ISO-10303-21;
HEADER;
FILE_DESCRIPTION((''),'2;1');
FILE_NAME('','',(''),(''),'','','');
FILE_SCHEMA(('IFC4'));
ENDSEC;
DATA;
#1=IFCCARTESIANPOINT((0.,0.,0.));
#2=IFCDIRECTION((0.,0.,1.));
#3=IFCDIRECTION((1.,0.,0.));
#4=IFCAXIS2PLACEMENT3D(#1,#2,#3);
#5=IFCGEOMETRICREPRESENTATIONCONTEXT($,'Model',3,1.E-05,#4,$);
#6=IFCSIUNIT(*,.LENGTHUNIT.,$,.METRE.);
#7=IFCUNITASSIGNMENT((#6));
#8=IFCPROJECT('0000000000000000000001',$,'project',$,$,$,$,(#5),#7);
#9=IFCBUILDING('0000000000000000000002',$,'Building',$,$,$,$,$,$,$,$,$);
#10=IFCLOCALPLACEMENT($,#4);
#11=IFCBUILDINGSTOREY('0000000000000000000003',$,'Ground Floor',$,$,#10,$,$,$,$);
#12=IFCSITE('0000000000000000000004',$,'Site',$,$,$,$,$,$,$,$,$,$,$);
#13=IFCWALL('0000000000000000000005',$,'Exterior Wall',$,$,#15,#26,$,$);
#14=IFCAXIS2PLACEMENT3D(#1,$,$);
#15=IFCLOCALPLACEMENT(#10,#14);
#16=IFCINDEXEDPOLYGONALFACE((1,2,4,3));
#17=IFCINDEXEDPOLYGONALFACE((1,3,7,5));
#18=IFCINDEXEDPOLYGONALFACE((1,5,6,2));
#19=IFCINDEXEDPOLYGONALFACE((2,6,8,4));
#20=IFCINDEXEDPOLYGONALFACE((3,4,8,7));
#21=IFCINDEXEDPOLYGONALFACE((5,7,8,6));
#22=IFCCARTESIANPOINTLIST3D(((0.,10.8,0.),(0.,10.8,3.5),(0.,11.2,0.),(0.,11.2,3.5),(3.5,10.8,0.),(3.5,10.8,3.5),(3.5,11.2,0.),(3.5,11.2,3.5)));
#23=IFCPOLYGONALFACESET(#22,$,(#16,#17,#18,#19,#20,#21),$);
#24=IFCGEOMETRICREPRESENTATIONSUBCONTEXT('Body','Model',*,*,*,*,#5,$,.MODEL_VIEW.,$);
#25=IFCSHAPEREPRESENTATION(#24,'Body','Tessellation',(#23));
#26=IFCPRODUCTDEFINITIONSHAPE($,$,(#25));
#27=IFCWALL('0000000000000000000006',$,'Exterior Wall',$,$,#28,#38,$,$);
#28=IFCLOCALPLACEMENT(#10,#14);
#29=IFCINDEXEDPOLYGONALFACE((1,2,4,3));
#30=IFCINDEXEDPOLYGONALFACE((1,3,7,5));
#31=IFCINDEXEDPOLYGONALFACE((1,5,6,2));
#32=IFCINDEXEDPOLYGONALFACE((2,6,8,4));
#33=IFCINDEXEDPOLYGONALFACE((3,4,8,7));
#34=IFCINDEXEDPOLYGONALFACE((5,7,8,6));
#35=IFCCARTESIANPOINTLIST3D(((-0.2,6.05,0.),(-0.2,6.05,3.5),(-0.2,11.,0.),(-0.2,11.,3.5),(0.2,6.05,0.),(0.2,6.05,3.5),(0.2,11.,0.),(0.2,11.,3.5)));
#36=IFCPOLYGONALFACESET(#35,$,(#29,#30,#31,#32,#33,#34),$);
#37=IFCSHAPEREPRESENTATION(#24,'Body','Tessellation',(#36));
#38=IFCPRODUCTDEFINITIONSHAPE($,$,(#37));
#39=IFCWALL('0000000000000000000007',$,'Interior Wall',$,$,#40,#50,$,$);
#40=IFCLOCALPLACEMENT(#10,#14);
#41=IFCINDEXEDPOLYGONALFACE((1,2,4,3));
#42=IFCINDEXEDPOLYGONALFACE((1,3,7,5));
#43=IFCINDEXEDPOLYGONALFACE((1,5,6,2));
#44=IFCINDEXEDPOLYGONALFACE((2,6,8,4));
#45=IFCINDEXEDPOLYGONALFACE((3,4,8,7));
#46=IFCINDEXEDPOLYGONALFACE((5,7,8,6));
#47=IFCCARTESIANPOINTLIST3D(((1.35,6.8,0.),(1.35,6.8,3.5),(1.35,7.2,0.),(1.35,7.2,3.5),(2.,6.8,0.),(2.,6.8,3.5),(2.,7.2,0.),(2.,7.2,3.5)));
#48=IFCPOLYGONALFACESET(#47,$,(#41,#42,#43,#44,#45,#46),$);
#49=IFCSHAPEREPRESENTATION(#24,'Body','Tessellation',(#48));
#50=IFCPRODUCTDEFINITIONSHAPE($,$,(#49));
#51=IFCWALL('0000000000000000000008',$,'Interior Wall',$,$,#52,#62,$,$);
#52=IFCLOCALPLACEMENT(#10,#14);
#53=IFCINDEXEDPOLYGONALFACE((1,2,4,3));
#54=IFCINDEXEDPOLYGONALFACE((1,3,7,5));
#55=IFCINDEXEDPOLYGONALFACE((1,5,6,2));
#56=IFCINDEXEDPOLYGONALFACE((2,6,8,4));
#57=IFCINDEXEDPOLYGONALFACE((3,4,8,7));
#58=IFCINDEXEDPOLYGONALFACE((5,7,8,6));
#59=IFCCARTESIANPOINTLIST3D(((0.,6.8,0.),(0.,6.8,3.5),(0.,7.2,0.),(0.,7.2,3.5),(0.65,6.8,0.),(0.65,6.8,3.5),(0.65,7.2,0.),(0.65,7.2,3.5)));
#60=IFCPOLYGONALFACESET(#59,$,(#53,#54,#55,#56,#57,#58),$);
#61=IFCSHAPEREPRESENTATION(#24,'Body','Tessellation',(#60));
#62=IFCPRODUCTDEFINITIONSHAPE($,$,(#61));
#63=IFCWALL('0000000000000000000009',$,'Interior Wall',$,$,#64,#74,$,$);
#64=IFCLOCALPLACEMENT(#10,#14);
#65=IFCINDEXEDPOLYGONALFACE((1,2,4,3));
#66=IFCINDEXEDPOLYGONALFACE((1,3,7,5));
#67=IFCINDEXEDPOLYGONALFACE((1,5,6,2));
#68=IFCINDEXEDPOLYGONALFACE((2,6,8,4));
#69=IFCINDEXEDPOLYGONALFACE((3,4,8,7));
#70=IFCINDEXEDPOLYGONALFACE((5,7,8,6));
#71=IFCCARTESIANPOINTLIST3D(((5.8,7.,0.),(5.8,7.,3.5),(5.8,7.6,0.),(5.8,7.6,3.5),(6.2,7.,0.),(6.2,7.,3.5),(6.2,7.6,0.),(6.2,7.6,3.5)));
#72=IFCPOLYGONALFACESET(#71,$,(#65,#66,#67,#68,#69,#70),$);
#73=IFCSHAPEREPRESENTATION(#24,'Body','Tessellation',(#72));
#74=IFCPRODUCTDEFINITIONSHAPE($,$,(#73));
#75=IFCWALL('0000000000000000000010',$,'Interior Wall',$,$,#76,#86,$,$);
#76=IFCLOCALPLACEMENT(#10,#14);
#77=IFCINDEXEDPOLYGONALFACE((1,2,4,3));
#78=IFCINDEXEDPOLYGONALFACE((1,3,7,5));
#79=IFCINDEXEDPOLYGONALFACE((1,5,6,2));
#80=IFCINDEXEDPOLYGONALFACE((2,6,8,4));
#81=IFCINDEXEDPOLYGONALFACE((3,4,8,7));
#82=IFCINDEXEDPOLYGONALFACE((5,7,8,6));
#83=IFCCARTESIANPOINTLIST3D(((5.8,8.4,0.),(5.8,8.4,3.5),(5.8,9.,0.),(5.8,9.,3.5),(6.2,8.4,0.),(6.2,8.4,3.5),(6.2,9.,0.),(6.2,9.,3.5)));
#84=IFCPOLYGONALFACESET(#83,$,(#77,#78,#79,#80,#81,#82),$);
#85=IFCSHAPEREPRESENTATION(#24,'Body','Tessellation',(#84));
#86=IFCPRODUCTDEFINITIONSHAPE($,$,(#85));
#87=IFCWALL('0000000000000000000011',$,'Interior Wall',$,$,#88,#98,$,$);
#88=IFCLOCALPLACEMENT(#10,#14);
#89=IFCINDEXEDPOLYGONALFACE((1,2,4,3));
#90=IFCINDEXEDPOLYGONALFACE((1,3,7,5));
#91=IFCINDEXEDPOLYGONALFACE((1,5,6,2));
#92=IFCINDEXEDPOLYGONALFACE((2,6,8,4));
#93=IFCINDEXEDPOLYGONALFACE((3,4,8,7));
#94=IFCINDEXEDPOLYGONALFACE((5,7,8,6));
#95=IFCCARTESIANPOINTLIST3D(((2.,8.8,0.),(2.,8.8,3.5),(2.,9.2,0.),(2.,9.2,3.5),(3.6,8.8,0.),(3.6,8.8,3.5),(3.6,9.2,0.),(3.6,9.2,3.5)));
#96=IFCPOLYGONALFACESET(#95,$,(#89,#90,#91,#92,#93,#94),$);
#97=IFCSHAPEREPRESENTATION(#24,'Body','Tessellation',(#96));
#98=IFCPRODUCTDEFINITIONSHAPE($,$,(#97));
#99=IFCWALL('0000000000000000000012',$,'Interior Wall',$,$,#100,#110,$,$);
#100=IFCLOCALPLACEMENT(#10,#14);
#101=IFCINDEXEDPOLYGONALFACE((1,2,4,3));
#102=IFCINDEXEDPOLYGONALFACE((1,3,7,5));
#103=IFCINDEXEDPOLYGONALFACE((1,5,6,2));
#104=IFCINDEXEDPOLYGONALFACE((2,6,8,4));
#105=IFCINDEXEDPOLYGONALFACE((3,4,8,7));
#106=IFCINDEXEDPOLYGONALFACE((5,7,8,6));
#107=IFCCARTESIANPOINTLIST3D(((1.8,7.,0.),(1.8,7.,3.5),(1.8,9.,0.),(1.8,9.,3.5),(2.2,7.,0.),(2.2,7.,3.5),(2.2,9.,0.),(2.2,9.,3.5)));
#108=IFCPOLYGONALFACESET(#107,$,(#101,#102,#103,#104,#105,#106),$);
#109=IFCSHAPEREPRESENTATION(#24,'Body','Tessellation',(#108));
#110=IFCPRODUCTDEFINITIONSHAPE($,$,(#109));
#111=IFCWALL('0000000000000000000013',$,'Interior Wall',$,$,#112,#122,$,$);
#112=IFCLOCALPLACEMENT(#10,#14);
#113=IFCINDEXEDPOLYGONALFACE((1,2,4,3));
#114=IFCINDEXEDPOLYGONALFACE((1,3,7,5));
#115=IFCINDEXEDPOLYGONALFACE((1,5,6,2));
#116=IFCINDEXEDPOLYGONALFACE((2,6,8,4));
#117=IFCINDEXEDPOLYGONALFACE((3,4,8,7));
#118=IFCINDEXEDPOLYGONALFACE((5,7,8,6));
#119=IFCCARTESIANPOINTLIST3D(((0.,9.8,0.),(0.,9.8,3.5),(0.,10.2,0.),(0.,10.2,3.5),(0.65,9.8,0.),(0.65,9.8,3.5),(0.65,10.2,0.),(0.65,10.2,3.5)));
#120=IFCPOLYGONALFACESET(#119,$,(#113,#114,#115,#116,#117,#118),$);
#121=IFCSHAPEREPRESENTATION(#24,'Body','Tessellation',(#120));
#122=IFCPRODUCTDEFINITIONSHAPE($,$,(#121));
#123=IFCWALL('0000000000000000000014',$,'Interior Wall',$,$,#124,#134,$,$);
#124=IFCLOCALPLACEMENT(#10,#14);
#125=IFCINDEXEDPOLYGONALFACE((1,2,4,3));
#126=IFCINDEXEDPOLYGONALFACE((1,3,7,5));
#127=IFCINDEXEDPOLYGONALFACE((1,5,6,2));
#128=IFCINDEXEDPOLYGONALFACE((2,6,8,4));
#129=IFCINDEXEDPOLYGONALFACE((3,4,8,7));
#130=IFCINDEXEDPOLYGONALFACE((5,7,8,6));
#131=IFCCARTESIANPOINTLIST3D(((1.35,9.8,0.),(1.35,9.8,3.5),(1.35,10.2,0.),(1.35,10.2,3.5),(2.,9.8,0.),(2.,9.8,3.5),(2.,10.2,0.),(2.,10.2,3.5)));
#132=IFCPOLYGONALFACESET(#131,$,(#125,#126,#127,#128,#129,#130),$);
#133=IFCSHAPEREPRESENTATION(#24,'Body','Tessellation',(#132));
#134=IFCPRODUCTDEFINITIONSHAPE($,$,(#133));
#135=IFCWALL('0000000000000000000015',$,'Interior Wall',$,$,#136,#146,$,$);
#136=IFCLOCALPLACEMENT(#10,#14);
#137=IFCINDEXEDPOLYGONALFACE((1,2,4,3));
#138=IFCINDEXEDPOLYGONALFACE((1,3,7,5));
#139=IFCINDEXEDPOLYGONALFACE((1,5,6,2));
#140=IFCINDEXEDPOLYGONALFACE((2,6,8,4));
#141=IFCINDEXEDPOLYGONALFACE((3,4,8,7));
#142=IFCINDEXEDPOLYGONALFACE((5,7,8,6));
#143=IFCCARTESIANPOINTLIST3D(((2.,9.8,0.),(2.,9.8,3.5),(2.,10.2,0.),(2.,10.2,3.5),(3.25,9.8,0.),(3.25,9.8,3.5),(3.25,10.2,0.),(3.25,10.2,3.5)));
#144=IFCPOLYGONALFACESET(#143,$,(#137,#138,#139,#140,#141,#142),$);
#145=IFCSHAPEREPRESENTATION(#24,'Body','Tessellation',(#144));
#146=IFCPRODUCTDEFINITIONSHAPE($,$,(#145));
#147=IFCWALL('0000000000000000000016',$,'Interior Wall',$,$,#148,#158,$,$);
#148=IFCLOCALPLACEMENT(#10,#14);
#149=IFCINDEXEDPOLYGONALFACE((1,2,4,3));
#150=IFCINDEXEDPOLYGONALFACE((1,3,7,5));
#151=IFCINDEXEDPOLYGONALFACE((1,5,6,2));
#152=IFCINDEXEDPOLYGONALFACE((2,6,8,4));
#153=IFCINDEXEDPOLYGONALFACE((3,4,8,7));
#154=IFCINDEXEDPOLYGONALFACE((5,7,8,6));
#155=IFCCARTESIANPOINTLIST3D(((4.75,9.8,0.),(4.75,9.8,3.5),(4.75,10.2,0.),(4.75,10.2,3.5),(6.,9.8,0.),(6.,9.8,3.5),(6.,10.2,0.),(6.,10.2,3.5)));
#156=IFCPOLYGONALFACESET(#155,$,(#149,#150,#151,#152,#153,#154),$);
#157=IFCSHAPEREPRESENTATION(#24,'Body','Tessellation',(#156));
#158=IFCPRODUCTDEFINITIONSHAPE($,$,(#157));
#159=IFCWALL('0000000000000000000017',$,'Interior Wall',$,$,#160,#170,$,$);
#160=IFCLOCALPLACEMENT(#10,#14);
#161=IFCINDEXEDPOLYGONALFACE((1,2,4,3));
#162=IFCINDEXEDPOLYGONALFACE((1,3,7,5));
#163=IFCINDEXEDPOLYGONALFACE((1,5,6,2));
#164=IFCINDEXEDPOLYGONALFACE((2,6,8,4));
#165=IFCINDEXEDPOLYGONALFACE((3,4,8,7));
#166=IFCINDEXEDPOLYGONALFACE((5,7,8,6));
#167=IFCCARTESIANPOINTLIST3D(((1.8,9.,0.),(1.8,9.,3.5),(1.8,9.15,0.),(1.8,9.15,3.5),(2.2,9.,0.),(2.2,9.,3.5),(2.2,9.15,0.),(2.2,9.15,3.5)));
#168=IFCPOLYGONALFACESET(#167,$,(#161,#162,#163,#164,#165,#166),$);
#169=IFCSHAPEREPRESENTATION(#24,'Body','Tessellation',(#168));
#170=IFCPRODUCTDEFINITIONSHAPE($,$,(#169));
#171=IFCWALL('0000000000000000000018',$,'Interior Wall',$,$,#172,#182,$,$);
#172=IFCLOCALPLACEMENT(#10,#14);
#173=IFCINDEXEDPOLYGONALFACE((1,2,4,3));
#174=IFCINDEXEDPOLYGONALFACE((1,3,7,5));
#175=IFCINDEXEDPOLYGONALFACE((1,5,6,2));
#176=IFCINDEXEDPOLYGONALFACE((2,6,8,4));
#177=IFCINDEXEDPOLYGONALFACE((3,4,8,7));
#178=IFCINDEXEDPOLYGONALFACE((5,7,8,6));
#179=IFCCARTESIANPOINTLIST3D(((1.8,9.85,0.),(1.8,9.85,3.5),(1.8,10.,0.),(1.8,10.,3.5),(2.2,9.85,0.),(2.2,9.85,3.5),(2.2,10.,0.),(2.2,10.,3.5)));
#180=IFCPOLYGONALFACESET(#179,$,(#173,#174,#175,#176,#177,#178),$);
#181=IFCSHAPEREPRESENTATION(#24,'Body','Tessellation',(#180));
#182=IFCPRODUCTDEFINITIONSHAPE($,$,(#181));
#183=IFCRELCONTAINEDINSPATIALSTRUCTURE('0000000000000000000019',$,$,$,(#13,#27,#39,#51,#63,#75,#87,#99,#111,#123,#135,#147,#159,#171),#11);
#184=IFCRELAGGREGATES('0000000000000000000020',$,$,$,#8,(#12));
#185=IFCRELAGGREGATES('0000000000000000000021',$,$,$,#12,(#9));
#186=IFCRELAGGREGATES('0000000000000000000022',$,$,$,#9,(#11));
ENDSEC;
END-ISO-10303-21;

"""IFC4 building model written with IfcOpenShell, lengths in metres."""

from ifc_helpers import new_model, si_unit, frame, origin_with_axes, place, context, subcontext, project, spatial, indexed_curve, outline, extrude, element, save


model = new_model("IFC4")

# Units and contexts
model_context = context("Model", 3, precision=1e-05, world=origin_with_axes())
body_context = subcontext(model_context, "Body", "Model", "MODEL_VIEW")
ifc_project = project(units=[si_unit("LENGTHUNIT", "METRE")], contexts=[model_context])

# Site, building, storey
site = spatial("IfcSite", under=ifc_project, Name="Site")
building = spatial("IfcBuilding", under=site, Name="Building")
storey_placement = place(None, origin_with_axes())
storey = spatial("IfcBuildingStorey", under=building, at=storey_placement, Name="Ground Floor")

# Walls
wall_1_placement = place(storey_placement, frame((3.5, 11.0, 0.0), z_axis=(0.0, 0.0, 1.0), x_axis=(-1.0, 0.0, 0.0)))
element("IfcWall", 1, at=wall_1_placement, inside=storey, Name="Exterior Wall", context=body_context, shape_type="SweptSolid", body=[
    extrude(outline(indexed_curve([(0.0, 0.0), (0.0, 0.4), (3.5, 0.4), (3.5, 0.0), (0.0, 0.0)], self_intersect=False)), frame((0.0, -0.2, 0.0), z_axis=(0.0, 0.0, 1.0), x_axis=(1.0, 0.0, 0.0)), (0.0, 0.0, 1.0), 3.5),
])
wall_2_placement = place(storey_placement, frame((0.0, 11.0, 0.0), z_axis=(0.0, 0.0, 1.0), x_axis=(0.0, -1.0, 0.0)))
element("IfcWall", 2, at=wall_2_placement, inside=storey, Name="Exterior Wall", context=body_context, shape_type="SweptSolid", body=[
    extrude(outline(indexed_curve([(0.0, 0.0), (0.0, 0.4), (4.95, 0.4), (4.95, 0.0), (0.0, 0.0)], self_intersect=False)), frame((0.0, -0.2, 0.0), z_axis=(0.0, 0.0, 1.0), x_axis=(1.0, 0.0, 0.0)), (0.0, 0.0, 1.0), 3.5),
])
for number, where, z_axis, x_axis, name in (
    (3, (2.0, 7.0, 0.0), (0.0, 0.0, 1.0), (-1.0, 0.0, 0.0), "Interior Wall"),
    (4, (0.65, 7.0, 0.0), (0.0, 0.0, 1.0), (-1.0, 0.0, 0.0), "Interior Wall"),
):
    element("IfcWall", number, at=place(storey_placement, frame(where, z_axis=z_axis, x_axis=x_axis)), inside=storey, Name=name, context=body_context, shape_type="SweptSolid", body=[
        extrude(outline(indexed_curve([(0.0, 0.0), (0.0, 0.4), (0.65, 0.4), (0.65, 0.0), (0.0, 0.0)], self_intersect=False)), frame((0.0, -0.2, 0.0), z_axis=(0.0, 0.0, 1.0), x_axis=(1.0, 0.0, 0.0)), (0.0, 0.0, 1.0), 3.5),
    ])
for number, where, z_axis, x_axis, name in (
    (5, (6.0, 7.0, 0.0), (0.0, 0.0, 1.0), (0.0, 1.0, 0.0), "Interior Wall"),
    (6, (6.0, 8.4, 0.0), (0.0, 0.0, 1.0), (0.0, 1.0, 0.0), "Interior Wall"),
):
    element("IfcWall", number, at=place(storey_placement, frame(where, z_axis=z_axis, x_axis=x_axis)), inside=storey, Name=name, context=body_context, shape_type="SweptSolid", body=[
        extrude(outline(indexed_curve([(0.0, 0.0), (0.0, 0.4), (0.6, 0.4), (0.6, 0.0), (0.0, 0.0)], self_intersect=False)), frame((0.0, -0.2, 0.0), z_axis=(0.0, 0.0, 1.0), x_axis=(1.0, 0.0, 0.0)), (0.0, 0.0, 1.0), 3.5),
    ])
wall_3_placement = place(storey_placement, frame((3.6, 9.0, 0.0), z_axis=(0.0, 0.0, 1.0), x_axis=(-1.0, 0.0, 0.0)))
element("IfcWall", 7, at=wall_3_placement, inside=storey, Name="Interior Wall", context=body_context, shape_type="SweptSolid", body=[
    extrude(outline(indexed_curve([(0.0, 0.0), (0.0, 0.4), (1.6, 0.4), (1.6, 0.0), (0.0, 0.0)], self_intersect=False)), frame((0.0, -0.2, 0.0), z_axis=(0.0, 0.0, 1.0), x_axis=(1.0, 0.0, 0.0)), (0.0, 0.0, 1.0), 3.5),
])
wall_4_placement = place(storey_placement, frame((2.0, 9.0, 0.0), z_axis=(0.0, 0.0, 1.0), x_axis=(0.0, -1.0, 0.0)))
element("IfcWall", 8, at=wall_4_placement, inside=storey, Name="Interior Wall", context=body_context, shape_type="SweptSolid", body=[
    extrude(outline(indexed_curve([(0.0, 0.0), (0.0, 0.4), (2.0, 0.4), (2.0, 0.0), (0.0, 0.0)], self_intersect=False)), frame((0.0, -0.2, 0.0), z_axis=(0.0, 0.0, 1.0), x_axis=(1.0, 0.0, 0.0)), (0.0, 0.0, 1.0), 3.5),
])
wall_5_placement = place(storey_placement, frame((0.0, 10.0, 0.0), z_axis=(0.0, 0.0, 1.0), x_axis=(1.0, 0.0, 0.0)))
element("IfcWall", 9, at=wall_5_placement, inside=storey, Name="Interior Wall", context=body_context, shape_type="SweptSolid", body=[
    extrude(outline(indexed_curve([(0.0, 0.0), (0.0, 0.4), (0.65, 0.4), (0.65, 0.0), (0.0, 0.0)], self_intersect=False)), frame((0.0, -0.2, 0.0), z_axis=(0.0, 0.0, 1.0), x_axis=(1.0, 0.0, 0.0)), (0.0, 0.0, 1.0), 3.5),
])
wall_6_placement = place(storey_placement, frame((1.35, 10.0, 0.0), z_axis=(0.0, 0.0, 1.0), x_axis=(1.0, 0.0, 0.0)))
element("IfcWall", 10, at=wall_6_placement, inside=storey, Name="Interior Wall", context=body_context, shape_type="SweptSolid", body=[
    extrude(outline(indexed_curve([(0.0, 0.0), (0.0, 0.4), (0.65, 0.4), (0.65, 0.0), (0.0, 0.0)], self_intersect=False)), frame((0.0, -0.2, 0.0), z_axis=(0.0, 0.0, 1.0), x_axis=(1.0, 0.0, 0.0)), (0.0, 0.0, 1.0), 3.5),
])
for number, where, z_axis, x_axis, name in (
    (11, (2.0, 10.0, 0.0), (0.0, 0.0, 1.0), (1.0, 0.0, 0.0), "Interior Wall"),
    (12, (4.75, 10.0, 0.0), (0.0, 0.0, 1.0), (1.0, 0.0, 0.0), "Interior Wall"),
):
    element("IfcWall", number, at=place(storey_placement, frame(where, z_axis=z_axis, x_axis=x_axis)), inside=storey, Name=name, context=body_context, shape_type="SweptSolid", body=[
        extrude(outline(indexed_curve([(0.0, 0.0), (0.0, 0.4), (1.25, 0.4), (1.25, 0.0), (0.0, 0.0)], self_intersect=False)), frame((0.0, -0.2, 0.0), z_axis=(0.0, 0.0, 1.0), x_axis=(1.0, 0.0, 0.0)), (0.0, 0.0, 1.0), 3.5),
    ])
for number, where, z_axis, x_axis, name in (
    (13, (2.0, 9.0, 0.0), (0.0, 0.0, 1.0), (0.0, 1.0, 0.0), "Interior Wall"),
    (14, (2.0, 9.85, 0.0), (0.0, 0.0, 1.0), (0.0, 1.0, 0.0), "Interior Wall"),
):
    element("IfcWall", number, at=place(storey_placement, frame(where, z_axis=z_axis, x_axis=x_axis)), inside=storey, Name=name, context=body_context, shape_type="SweptSolid", body=[
        extrude(outline(indexed_curve([(0.0, 0.0), (0.0, 0.4), (0.15, 0.4), (0.15, 0.0), (0.0, 0.0)], self_intersect=False)), frame((0.0, -0.2, 0.0), z_axis=(0.0, 0.0, 1.0), x_axis=(1.0, 0.0, 0.0)), (0.0, 0.0, 1.0), 3.5),
    ])

save(model, "model.ifc")
